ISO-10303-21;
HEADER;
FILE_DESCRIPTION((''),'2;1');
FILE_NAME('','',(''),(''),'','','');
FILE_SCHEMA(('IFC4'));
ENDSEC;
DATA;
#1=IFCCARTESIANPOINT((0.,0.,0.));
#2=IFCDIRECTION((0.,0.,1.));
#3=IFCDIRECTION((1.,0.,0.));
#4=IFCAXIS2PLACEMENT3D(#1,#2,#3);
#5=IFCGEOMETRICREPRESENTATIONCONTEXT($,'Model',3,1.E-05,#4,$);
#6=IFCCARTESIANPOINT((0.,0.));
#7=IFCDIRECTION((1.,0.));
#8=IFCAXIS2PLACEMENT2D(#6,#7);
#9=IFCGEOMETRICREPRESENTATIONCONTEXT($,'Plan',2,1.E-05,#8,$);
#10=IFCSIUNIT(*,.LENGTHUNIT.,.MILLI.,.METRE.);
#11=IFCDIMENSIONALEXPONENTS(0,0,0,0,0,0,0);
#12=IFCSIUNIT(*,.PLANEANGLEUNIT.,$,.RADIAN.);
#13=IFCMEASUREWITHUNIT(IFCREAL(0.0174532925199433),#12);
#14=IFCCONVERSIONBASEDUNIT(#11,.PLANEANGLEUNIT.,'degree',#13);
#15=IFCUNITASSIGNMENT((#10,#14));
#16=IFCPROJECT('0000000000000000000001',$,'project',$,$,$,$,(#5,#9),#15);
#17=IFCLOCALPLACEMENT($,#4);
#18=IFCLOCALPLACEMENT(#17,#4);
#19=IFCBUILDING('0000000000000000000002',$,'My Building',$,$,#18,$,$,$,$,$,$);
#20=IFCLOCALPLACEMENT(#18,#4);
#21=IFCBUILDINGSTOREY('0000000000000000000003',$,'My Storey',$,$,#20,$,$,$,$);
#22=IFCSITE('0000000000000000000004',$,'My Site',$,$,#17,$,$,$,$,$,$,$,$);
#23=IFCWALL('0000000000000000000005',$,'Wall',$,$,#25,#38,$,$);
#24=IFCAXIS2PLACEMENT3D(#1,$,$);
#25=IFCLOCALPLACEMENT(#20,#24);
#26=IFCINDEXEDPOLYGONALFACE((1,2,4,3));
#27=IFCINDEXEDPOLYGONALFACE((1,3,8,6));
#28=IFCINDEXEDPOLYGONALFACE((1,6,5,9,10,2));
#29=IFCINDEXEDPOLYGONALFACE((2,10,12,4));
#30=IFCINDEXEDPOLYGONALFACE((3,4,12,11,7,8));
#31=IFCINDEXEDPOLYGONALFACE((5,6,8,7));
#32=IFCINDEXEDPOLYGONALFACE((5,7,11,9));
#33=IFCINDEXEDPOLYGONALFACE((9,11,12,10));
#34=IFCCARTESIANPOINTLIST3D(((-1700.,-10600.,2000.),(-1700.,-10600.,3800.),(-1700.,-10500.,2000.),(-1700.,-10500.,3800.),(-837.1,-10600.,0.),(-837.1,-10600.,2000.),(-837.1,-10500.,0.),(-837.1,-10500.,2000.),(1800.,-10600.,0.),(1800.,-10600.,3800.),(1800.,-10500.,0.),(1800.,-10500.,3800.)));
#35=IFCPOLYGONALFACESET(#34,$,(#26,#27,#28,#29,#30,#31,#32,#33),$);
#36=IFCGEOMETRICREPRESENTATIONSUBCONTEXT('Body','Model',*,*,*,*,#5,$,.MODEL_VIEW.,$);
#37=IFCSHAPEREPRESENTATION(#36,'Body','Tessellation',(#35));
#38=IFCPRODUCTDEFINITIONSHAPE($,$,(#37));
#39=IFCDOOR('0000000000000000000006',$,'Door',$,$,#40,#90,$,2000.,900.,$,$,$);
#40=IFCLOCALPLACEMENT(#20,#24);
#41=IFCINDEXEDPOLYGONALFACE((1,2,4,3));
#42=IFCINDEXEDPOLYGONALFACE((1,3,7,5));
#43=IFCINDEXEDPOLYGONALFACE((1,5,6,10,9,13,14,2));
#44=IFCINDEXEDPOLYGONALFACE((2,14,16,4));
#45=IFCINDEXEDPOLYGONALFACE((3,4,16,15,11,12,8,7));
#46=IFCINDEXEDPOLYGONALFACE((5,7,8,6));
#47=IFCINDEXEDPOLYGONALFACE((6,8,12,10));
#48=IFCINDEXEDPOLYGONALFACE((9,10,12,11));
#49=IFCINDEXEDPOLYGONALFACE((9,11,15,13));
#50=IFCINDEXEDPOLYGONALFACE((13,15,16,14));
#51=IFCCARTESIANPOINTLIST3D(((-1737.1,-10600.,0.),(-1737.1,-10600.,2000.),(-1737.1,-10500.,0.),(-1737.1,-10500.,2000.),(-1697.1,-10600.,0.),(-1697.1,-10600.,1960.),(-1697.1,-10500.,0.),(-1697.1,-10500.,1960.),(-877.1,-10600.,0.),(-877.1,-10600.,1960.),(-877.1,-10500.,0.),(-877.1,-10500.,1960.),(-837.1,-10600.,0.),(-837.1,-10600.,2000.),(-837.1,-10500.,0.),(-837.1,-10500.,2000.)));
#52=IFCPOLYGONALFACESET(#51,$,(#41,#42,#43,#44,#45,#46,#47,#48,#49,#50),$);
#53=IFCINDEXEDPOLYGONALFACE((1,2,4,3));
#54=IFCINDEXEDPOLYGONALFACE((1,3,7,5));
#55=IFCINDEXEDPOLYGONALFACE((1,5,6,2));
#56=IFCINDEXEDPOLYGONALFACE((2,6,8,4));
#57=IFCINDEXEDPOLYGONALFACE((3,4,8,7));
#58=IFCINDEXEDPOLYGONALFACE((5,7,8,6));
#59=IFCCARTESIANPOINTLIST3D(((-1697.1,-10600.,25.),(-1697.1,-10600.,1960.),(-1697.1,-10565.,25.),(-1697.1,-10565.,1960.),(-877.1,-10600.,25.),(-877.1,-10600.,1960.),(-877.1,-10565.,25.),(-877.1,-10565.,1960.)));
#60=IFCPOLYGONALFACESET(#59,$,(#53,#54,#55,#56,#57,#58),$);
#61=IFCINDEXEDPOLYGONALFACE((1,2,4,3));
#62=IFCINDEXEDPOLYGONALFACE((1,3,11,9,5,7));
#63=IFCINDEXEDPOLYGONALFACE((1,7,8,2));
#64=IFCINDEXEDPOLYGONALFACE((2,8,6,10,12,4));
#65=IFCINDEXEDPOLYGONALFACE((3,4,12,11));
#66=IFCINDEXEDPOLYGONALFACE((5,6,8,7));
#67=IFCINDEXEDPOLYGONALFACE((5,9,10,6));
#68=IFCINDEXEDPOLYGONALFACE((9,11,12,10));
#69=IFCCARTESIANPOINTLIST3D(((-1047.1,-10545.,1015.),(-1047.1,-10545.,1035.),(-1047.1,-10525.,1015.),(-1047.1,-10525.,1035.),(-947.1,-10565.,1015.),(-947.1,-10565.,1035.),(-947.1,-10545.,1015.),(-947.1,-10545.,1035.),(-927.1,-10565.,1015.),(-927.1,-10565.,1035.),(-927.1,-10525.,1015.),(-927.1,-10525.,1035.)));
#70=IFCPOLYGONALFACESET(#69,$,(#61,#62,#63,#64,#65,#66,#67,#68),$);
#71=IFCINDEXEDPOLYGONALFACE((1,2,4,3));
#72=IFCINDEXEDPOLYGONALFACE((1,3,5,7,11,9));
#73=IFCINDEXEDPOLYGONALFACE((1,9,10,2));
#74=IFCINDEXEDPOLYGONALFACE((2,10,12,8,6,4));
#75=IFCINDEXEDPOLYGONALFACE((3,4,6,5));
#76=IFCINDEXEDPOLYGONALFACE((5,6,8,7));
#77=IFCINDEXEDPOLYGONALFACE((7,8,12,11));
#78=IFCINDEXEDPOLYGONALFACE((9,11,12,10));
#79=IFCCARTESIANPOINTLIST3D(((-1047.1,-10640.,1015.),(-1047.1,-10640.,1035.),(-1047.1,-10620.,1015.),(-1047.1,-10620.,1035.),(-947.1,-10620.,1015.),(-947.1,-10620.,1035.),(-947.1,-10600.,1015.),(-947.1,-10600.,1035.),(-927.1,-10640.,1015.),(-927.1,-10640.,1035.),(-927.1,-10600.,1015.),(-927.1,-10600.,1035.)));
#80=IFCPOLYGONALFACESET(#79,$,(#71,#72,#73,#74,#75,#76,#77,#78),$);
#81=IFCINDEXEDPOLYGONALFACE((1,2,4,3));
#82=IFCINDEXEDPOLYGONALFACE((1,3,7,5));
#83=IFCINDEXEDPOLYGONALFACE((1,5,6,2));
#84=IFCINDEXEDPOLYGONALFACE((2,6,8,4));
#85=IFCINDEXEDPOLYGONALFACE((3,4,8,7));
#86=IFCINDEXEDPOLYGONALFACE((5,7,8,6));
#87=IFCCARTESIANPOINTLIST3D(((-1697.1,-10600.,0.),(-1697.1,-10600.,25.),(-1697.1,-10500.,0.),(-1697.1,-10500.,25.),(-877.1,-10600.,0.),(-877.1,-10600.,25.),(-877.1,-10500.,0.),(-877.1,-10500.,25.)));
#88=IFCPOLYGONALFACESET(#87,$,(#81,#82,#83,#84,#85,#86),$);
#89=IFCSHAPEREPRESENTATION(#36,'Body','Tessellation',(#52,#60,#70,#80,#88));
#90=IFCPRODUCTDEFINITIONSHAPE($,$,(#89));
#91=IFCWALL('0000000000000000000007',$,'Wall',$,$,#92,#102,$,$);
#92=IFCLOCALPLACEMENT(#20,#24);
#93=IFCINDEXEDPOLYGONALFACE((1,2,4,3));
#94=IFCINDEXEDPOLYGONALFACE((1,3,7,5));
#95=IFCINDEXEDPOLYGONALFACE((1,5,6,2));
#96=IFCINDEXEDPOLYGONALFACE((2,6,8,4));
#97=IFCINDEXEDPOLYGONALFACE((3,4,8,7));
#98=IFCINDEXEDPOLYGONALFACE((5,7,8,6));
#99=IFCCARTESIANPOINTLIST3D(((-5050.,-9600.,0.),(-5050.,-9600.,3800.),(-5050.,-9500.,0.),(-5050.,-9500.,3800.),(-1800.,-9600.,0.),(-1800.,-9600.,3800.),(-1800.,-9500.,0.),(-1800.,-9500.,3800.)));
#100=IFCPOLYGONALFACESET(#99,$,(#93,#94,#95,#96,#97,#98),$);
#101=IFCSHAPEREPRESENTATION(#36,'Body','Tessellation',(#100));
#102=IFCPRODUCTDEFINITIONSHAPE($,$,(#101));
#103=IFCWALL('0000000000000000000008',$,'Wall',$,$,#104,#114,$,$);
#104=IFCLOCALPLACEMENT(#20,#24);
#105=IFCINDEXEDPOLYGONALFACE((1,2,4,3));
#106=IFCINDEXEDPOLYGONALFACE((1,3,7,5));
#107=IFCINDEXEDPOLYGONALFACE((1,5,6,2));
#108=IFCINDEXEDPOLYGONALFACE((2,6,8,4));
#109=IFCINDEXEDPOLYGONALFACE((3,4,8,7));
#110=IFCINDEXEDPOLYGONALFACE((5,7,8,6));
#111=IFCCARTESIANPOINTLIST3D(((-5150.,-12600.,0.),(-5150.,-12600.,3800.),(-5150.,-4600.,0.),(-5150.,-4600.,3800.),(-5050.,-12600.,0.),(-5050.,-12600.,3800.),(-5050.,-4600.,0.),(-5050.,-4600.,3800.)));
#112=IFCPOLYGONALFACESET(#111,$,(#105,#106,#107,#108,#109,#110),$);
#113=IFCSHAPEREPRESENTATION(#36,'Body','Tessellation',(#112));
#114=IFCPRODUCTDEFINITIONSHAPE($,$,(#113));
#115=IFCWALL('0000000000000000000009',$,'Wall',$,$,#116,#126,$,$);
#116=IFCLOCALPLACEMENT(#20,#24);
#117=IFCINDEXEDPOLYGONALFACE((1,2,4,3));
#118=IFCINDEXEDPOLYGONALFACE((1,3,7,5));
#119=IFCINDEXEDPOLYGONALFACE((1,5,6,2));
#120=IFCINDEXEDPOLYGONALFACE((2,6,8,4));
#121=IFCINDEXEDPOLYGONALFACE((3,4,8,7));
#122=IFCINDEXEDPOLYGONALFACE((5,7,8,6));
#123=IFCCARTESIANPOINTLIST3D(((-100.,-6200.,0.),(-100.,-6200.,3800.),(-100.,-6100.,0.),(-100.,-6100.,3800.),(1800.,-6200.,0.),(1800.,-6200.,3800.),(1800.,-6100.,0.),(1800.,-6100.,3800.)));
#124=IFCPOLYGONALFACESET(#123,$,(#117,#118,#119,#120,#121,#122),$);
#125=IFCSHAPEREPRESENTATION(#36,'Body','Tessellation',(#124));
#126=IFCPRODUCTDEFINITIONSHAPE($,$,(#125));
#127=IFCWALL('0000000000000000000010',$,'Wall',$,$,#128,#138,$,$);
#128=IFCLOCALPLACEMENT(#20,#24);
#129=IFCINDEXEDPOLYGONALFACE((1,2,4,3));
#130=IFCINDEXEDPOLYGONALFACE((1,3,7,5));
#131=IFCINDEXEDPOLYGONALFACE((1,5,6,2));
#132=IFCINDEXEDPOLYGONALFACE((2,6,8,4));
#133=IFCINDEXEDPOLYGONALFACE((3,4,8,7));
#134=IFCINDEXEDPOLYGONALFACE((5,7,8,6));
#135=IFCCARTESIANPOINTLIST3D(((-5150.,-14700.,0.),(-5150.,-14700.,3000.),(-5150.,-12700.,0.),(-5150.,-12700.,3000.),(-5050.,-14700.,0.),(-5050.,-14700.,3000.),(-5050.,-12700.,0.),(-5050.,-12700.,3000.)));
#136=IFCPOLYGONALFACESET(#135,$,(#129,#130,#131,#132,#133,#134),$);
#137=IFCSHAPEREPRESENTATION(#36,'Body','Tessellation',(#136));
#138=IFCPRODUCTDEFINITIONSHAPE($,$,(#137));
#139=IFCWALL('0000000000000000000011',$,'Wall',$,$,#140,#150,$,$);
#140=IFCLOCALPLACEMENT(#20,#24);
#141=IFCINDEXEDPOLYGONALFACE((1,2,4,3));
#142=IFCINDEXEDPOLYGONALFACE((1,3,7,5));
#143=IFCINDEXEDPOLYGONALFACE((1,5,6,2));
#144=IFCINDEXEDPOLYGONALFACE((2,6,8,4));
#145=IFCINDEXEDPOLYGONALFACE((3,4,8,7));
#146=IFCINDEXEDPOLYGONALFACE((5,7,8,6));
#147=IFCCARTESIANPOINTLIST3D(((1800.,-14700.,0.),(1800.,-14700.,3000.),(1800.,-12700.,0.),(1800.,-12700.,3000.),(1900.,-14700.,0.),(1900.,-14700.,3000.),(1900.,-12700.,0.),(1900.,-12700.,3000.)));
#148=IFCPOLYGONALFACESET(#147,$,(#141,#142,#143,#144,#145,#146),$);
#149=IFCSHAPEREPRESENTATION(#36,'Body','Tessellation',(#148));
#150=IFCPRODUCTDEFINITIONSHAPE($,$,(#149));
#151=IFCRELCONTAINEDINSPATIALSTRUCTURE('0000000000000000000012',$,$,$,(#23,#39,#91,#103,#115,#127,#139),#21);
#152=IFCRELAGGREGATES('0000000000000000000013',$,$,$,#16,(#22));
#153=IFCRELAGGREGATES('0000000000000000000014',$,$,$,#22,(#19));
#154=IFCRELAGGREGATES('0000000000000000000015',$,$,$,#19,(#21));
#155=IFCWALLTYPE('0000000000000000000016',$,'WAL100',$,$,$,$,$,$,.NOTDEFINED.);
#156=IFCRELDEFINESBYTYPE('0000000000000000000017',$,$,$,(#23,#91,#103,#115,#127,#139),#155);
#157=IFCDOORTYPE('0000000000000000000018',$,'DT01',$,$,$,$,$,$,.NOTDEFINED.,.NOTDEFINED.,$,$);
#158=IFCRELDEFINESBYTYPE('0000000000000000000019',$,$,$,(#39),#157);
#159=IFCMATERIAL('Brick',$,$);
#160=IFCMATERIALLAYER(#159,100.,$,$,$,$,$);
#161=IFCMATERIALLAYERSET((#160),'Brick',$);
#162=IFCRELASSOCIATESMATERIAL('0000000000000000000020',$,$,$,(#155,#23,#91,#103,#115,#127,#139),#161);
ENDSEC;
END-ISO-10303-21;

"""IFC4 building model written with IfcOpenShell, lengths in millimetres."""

from ifc_helpers import new_model, entity, si_unit, converted_unit, frame, origin_with_axes, origin_2d_with_axis, place, context, subcontext, project, spatial, line, indexed_curve, outline, extrude, shape, source, transform, mapped, material, layer, layer_set, layer_usage, type_object, type_shapes, element, fill, save


model = new_model("IFC4")

# Units and contexts
model_context = context("Model", 3, precision=1e-05, world=origin_with_axes())
plan_context = context("Plan", 2, precision=1e-05, world=origin_2d_with_axis())
body_context_1 = subcontext(model_context, "Body", "Model", "MODEL_VIEW")
body_context_2 = subcontext(plan_context, "Body", "Plan", "PLAN_VIEW")
ifc_project = project(units=[si_unit("LENGTHUNIT", "METRE", prefix="MILLI"), converted_unit("PLANEANGLEUNIT", "degree", entity("IfcReal", 0.0174532925199433), si_unit("PLANEANGLEUNIT", "RADIAN"), dimensions=[0, 0, 0, 0, 0, 0, 0])], contexts=[model_context, plan_context])

# Site, building, storey
site_placement = place(None, origin_with_axes())
site = spatial("IfcSite", under=ifc_project, at=site_placement, Name="My Site")
building_placement = place(site_placement, origin_with_axes())
building = spatial("IfcBuilding", under=site, at=building_placement, Name="My Building")
storey_placement = place(building_placement, origin_with_axes())
storey = spatial("IfcBuildingStorey", under=building, at=storey_placement, Name="My Storey")

# Shared definitions
ifc_material = material(Name="Brick")
ifc_layer_1 = layer(ifc_material, 100.0)
ifc_layer_set_1 = layer_set([ifc_layer_1], Name="Brick")
wall_type = type_object("IfcWallType", Name="WAL100", PredefinedType="NOTDEFINED", material=ifc_layer_set_1)

# Wall, opening, door
ifc_layer_usage_1 = layer_usage(ifc_layer_set_1, "AXIS2", "POSITIVE", 0.0)
wall_1_placement = place(storey_placement, frame((1800.0, -10500.0, 0.0), z_axis=(0.0, 0.0, 1.0), x_axis=(-1.0, 0.000002, 0.0)))
wall_1 = element("IfcWall", 1, at=wall_1_placement, inside=storey, type_object=wall_type, material=ifc_layer_usage_1, Name="Wall", context=body_context_1, shape_type="SweptSolid", body=[
    extrude(outline(indexed_curve([(0.0, 0.0), (0.0, 100.0), (3500.0, 100.0), (3500.0, 0.0), (0.0, 0.0)], self_intersect=False)), origin_with_axes(), (0.0, 0.0, 1.0), 3800.0),
])
shared_shape_1 = source(origin_with_axes(), body_context_1, "Body", "SweptSolid", [
    extrude(outline(indexed_curve([(0.0, 0.0), (900.0, 0.0), (900.0, 2000.0), (0.0, 2000.0)], segments=[line(1, 2, 3, 4, 1)])), frame((0.0, -100.0, 0.0), z_axis=(0.0, -1.0, 0.0), x_axis=(1.0, 0.0, 0.0)), (0.0, 0.0, -1.0), 300.0),
])
opening_1_placement = place(wall_1_placement, frame((2637.1, 0.0, 0.0), z_axis=(0.0, 0.0, 1.0), x_axis=(1.0, 0.0, 0.0)))
opening_1 = element("IfcOpeningElement", 2, at=opening_1_placement, cuts=wall_1, PredefinedType="OPENING", context=body_context_1, shape_type="MappedRepresentation", body=[
    mapped(shared_shape_1, transform((0.0, 0.0, 0.0), x_axis=(1.0, 0.0, 0.0), y_axis=(0.0, 1.0, 0.0), z_axis=(0.0, 0.0, 1.0), scale=1.0)),
])
door_type_1 = type_object("IfcDoorType", Name="DT01", OperationType="NOTDEFINED", PredefinedType="NOTDEFINED")
shared_shape_2 = source(origin_with_axes(), body_context_1, "Body", "SweptSolid", [
    extrude(outline(indexed_curve([(0.0, 0.0), (0.0, 2000.0), (900.0, 2000.0), (900.0, 0.0), (860.0, 0.0), (860.0, 1960.0), (40.0, 1960.0), (40.0, 0.0)], segments=[line(1, 2, 3, 4, 5, 6, 7, 8, 1)])), frame((0.0, 0.0, 0.0), z_axis=(0.0, -1.0, 0.0), x_axis=(1.0, 0.0, 0.0)), (0.0, 0.0, -1.0), 100.0),
    extrude(outline(indexed_curve([(0.0, 0.0), (820.0, 0.0), (820.0, 35.0), (0.0, 35.0)], segments=[line(1, 2, 3, 4, 1)])), frame((40.0, 65.0, 25.0), z_axis=(0.0, 0.0, 1.0), x_axis=(1.0, 0.0, 0.0)), (0.0, 0.0, 1.0), 1935.0),
    extrude(outline(indexed_curve([(0.0, 0.0), (0.0, -40.0), (120.0, -40.0), (120.0, -20.0), (20.0, -20.0), (20.0, 0.0)], segments=[line(1, 2, 3, 4, 5, 6, 1)])), frame((90.0, 65.0, 1015.0), z_axis=(0.0, 0.0, 1.0), x_axis=(1.0, 0.0, 0.0)), (0.0, 0.0, 1.0), 20.0),
    extrude(outline(indexed_curve([(0.0, 0.0), (0.0, 40.0), (120.0, 40.0), (120.0, 20.0), (20.0, 20.0), (20.0, 0.0)], segments=[line(1, 2, 3, 4, 5, 6, 1)])), frame((90.0, 100.0, 1015.0), z_axis=(0.0, 0.0, 1.0), x_axis=(1.0, 0.0, 0.0)), (0.0, 0.0, 1.0), 20.0),
    extrude(outline(indexed_curve([(0.0, 0.0), (820.0, 0.0), (820.0, 100.0), (0.0, 100.0)], segments=[line(1, 2, 3, 4, 1)])), frame((40.0, 0.0, 0.0), z_axis=(0.0, 0.0, 1.0), x_axis=(1.0, 0.0, 0.0)), (0.0, 0.0, 1.0), 25.0),
])
shared_shape_3 = source(origin_with_axes(), body_context_2, "Body", "Curve2D", [
    entity("IfcIndexedPolyCurve", entity("IfcCartesianPointList2D", [[0.0, 0.0], [40.0, 0.0], [40.0, 100.0], [0.0, 100.0]]), [entity("IfcLineIndex", [1, 2, 3, 4, 1])]),
    entity("IfcIndexedPolyCurve", entity("IfcCartesianPointList2D", [[900.0, 0.0], [860.0, 0.0], [860.0, 100.0], [900.0, 100.0]]), [entity("IfcLineIndex", [1, 2, 3, 4, 1])]),
    entity("IfcTrimmedCurve", entity("IfcEllipse", entity("IfcAxis2Placement2D", entity("IfcCartesianPoint", [825.0, 100.0]), entity("IfcDirection", [1.0, 0.0])), 785.0, 820.0), [entity("IfcCartesianPoint", [825.0, 920.0])], [entity("IfcCartesianPoint", [40.0, 100.0])], True, "CARTESIAN"),
    entity("IfcIndexedPolyCurve", entity("IfcCartesianPointList2D", [[860.0, 100.0], [825.0, 100.0], [825.0, 920.0], [860.0, 920.0]]), [entity("IfcLineIndex", [1, 2, 3, 4, 1])]),
])
type_shapes(door_type_1, [shared_shape_2, shared_shape_3])
door_1_placement = place(opening_1_placement, frame((0.0, 0.0, 0.0), z_axis=(0.0, 0.0, 1.0), x_axis=(1.0, 0.0, 0.0)))
door_1 = element("IfcDoor", 3, at=door_1_placement, inside=storey, type_object=door_type_1, Name="Door", OverallHeight=2000.0, OverallWidth=900.0, shapes=[
    shape(body_context_1, "Body", "MappedRepresentation", [mapped(shared_shape_2, transform((0.0, 0.0, 0.0), x_axis=(1.0, 0.0, 0.0), y_axis=(0.0, 1.0, 0.0), z_axis=(0.0, 0.0, 1.0), scale=1.0))]),
    shape(body_context_2, "Body", "MappedRepresentation", [mapped(shared_shape_3, transform((0.0, 0.0, 0.0), x_axis=(1.0, 0.0, 0.0), y_axis=(0.0, 1.0, 0.0), z_axis=(0.0, 0.0, 1.0), scale=1.0))]),
])
fill(opening_1, door_1)

# Walls
ifc_layer_usage_2 = layer_usage(ifc_layer_set_1, "AXIS2", "POSITIVE", 0.0)
wall_2_placement = place(storey_placement, frame((-1800.0, -9500.0, 0.0), z_axis=(0.0, 0.0, 1.0), x_axis=(-1.0, 0.000001, 0.0)))
element("IfcWall", 4, at=wall_2_placement, inside=storey, type_object=wall_type, material=ifc_layer_usage_2, Name="Wall", context=body_context_1, shape_type="SweptSolid", body=[
    extrude(outline(indexed_curve([(0.0, 0.0), (0.0, 100.0), (3250.0, 100.0), (3250.0, 0.0), (0.0, 0.0)], self_intersect=False)), origin_with_axes(), (0.0, 0.0, 1.0), 3800.0),
])
ifc_layer_usage_3 = layer_usage(ifc_layer_set_1, "AXIS2", "POSITIVE", 0.0)
wall_3_placement = place(storey_placement, frame((-5050.0, -12600.0, 0.0), z_axis=(0.0, 0.0, 1.0), x_axis=(0.000004, 1.0, 0.0)))
element("IfcWall", 5, at=wall_3_placement, inside=storey, type_object=wall_type, material=ifc_layer_usage_3, Name="Wall", context=body_context_1, shape_type="SweptSolid", body=[
    extrude(outline(indexed_curve([(0.0, 0.0), (0.0, 100.0), (8000.0, 100.0), (8000.0, 0.0), (0.0, 0.0)], self_intersect=False)), origin_with_axes(), (0.0, 0.0, 1.0), 3800.0),
])
ifc_layer_usage_4 = layer_usage(ifc_layer_set_1, "AXIS2", "POSITIVE", 0.0)
wall_4_placement = place(storey_placement, frame((1800.0, -6100.0, 0.0), z_axis=(0.0, 0.0, 1.0), x_axis=(-1.0, 0.000001, 0.0)))
element("IfcWall", 6, at=wall_4_placement, inside=storey, type_object=wall_type, material=ifc_layer_usage_4, Name="Wall", context=body_context_1, shape_type="SweptSolid", body=[
    extrude(outline(indexed_curve([(0.0, 0.0), (0.0, 100.0), (1900.0, 100.0), (1900.0, 0.0), (0.0, 0.0)], self_intersect=False)), origin_with_axes(), (0.0, 0.0, 1.0), 3800.0),
])
ifc_layer_usage_5 = layer_usage(ifc_layer_set_1, "AXIS2", "POSITIVE", 0.0)
wall_5_placement = place(storey_placement, frame((-5150.0, -12700.0, 0.0), z_axis=(0.0, 0.0, 1.0), x_axis=(-0.000001, -1.0, 0.0)))
element("IfcWall", 7, at=wall_5_placement, inside=storey, type_object=wall_type, material=ifc_layer_usage_5, Name="Wall", context=body_context_1, shape_type="SweptSolid", body=[
    extrude(outline(indexed_curve([(0.0, 0.0), (0.0, 100.0), (2000.0, 100.0), (2000.0, 0.0), (0.0, 0.0)], self_intersect=False)), origin_with_axes(), (0.0, 0.0, 1.0), 3000.0),
])
ifc_layer_usage_6 = layer_usage(ifc_layer_set_1, "AXIS2", "POSITIVE", 0.0)
wall_6_placement = place(storey_placement, frame((1900.0, -14700.0, 0.0), z_axis=(0.0, 0.0, 1.0), x_axis=(0.000001, 1.0, 0.0)))
element("IfcWall", 8, at=wall_6_placement, inside=storey, type_object=wall_type, material=ifc_layer_usage_6, Name="Wall", context=body_context_1, shape_type="SweptSolid", body=[
    extrude(outline(indexed_curve([(0.0, 0.0), (0.0, 100.0), (2000.0, 100.0), (2000.0, 0.0), (0.0, 0.0)], self_intersect=False)), origin_with_axes(), (0.0, 0.0, 1.0), 3000.0),
])

save(model, "model.ifc")
